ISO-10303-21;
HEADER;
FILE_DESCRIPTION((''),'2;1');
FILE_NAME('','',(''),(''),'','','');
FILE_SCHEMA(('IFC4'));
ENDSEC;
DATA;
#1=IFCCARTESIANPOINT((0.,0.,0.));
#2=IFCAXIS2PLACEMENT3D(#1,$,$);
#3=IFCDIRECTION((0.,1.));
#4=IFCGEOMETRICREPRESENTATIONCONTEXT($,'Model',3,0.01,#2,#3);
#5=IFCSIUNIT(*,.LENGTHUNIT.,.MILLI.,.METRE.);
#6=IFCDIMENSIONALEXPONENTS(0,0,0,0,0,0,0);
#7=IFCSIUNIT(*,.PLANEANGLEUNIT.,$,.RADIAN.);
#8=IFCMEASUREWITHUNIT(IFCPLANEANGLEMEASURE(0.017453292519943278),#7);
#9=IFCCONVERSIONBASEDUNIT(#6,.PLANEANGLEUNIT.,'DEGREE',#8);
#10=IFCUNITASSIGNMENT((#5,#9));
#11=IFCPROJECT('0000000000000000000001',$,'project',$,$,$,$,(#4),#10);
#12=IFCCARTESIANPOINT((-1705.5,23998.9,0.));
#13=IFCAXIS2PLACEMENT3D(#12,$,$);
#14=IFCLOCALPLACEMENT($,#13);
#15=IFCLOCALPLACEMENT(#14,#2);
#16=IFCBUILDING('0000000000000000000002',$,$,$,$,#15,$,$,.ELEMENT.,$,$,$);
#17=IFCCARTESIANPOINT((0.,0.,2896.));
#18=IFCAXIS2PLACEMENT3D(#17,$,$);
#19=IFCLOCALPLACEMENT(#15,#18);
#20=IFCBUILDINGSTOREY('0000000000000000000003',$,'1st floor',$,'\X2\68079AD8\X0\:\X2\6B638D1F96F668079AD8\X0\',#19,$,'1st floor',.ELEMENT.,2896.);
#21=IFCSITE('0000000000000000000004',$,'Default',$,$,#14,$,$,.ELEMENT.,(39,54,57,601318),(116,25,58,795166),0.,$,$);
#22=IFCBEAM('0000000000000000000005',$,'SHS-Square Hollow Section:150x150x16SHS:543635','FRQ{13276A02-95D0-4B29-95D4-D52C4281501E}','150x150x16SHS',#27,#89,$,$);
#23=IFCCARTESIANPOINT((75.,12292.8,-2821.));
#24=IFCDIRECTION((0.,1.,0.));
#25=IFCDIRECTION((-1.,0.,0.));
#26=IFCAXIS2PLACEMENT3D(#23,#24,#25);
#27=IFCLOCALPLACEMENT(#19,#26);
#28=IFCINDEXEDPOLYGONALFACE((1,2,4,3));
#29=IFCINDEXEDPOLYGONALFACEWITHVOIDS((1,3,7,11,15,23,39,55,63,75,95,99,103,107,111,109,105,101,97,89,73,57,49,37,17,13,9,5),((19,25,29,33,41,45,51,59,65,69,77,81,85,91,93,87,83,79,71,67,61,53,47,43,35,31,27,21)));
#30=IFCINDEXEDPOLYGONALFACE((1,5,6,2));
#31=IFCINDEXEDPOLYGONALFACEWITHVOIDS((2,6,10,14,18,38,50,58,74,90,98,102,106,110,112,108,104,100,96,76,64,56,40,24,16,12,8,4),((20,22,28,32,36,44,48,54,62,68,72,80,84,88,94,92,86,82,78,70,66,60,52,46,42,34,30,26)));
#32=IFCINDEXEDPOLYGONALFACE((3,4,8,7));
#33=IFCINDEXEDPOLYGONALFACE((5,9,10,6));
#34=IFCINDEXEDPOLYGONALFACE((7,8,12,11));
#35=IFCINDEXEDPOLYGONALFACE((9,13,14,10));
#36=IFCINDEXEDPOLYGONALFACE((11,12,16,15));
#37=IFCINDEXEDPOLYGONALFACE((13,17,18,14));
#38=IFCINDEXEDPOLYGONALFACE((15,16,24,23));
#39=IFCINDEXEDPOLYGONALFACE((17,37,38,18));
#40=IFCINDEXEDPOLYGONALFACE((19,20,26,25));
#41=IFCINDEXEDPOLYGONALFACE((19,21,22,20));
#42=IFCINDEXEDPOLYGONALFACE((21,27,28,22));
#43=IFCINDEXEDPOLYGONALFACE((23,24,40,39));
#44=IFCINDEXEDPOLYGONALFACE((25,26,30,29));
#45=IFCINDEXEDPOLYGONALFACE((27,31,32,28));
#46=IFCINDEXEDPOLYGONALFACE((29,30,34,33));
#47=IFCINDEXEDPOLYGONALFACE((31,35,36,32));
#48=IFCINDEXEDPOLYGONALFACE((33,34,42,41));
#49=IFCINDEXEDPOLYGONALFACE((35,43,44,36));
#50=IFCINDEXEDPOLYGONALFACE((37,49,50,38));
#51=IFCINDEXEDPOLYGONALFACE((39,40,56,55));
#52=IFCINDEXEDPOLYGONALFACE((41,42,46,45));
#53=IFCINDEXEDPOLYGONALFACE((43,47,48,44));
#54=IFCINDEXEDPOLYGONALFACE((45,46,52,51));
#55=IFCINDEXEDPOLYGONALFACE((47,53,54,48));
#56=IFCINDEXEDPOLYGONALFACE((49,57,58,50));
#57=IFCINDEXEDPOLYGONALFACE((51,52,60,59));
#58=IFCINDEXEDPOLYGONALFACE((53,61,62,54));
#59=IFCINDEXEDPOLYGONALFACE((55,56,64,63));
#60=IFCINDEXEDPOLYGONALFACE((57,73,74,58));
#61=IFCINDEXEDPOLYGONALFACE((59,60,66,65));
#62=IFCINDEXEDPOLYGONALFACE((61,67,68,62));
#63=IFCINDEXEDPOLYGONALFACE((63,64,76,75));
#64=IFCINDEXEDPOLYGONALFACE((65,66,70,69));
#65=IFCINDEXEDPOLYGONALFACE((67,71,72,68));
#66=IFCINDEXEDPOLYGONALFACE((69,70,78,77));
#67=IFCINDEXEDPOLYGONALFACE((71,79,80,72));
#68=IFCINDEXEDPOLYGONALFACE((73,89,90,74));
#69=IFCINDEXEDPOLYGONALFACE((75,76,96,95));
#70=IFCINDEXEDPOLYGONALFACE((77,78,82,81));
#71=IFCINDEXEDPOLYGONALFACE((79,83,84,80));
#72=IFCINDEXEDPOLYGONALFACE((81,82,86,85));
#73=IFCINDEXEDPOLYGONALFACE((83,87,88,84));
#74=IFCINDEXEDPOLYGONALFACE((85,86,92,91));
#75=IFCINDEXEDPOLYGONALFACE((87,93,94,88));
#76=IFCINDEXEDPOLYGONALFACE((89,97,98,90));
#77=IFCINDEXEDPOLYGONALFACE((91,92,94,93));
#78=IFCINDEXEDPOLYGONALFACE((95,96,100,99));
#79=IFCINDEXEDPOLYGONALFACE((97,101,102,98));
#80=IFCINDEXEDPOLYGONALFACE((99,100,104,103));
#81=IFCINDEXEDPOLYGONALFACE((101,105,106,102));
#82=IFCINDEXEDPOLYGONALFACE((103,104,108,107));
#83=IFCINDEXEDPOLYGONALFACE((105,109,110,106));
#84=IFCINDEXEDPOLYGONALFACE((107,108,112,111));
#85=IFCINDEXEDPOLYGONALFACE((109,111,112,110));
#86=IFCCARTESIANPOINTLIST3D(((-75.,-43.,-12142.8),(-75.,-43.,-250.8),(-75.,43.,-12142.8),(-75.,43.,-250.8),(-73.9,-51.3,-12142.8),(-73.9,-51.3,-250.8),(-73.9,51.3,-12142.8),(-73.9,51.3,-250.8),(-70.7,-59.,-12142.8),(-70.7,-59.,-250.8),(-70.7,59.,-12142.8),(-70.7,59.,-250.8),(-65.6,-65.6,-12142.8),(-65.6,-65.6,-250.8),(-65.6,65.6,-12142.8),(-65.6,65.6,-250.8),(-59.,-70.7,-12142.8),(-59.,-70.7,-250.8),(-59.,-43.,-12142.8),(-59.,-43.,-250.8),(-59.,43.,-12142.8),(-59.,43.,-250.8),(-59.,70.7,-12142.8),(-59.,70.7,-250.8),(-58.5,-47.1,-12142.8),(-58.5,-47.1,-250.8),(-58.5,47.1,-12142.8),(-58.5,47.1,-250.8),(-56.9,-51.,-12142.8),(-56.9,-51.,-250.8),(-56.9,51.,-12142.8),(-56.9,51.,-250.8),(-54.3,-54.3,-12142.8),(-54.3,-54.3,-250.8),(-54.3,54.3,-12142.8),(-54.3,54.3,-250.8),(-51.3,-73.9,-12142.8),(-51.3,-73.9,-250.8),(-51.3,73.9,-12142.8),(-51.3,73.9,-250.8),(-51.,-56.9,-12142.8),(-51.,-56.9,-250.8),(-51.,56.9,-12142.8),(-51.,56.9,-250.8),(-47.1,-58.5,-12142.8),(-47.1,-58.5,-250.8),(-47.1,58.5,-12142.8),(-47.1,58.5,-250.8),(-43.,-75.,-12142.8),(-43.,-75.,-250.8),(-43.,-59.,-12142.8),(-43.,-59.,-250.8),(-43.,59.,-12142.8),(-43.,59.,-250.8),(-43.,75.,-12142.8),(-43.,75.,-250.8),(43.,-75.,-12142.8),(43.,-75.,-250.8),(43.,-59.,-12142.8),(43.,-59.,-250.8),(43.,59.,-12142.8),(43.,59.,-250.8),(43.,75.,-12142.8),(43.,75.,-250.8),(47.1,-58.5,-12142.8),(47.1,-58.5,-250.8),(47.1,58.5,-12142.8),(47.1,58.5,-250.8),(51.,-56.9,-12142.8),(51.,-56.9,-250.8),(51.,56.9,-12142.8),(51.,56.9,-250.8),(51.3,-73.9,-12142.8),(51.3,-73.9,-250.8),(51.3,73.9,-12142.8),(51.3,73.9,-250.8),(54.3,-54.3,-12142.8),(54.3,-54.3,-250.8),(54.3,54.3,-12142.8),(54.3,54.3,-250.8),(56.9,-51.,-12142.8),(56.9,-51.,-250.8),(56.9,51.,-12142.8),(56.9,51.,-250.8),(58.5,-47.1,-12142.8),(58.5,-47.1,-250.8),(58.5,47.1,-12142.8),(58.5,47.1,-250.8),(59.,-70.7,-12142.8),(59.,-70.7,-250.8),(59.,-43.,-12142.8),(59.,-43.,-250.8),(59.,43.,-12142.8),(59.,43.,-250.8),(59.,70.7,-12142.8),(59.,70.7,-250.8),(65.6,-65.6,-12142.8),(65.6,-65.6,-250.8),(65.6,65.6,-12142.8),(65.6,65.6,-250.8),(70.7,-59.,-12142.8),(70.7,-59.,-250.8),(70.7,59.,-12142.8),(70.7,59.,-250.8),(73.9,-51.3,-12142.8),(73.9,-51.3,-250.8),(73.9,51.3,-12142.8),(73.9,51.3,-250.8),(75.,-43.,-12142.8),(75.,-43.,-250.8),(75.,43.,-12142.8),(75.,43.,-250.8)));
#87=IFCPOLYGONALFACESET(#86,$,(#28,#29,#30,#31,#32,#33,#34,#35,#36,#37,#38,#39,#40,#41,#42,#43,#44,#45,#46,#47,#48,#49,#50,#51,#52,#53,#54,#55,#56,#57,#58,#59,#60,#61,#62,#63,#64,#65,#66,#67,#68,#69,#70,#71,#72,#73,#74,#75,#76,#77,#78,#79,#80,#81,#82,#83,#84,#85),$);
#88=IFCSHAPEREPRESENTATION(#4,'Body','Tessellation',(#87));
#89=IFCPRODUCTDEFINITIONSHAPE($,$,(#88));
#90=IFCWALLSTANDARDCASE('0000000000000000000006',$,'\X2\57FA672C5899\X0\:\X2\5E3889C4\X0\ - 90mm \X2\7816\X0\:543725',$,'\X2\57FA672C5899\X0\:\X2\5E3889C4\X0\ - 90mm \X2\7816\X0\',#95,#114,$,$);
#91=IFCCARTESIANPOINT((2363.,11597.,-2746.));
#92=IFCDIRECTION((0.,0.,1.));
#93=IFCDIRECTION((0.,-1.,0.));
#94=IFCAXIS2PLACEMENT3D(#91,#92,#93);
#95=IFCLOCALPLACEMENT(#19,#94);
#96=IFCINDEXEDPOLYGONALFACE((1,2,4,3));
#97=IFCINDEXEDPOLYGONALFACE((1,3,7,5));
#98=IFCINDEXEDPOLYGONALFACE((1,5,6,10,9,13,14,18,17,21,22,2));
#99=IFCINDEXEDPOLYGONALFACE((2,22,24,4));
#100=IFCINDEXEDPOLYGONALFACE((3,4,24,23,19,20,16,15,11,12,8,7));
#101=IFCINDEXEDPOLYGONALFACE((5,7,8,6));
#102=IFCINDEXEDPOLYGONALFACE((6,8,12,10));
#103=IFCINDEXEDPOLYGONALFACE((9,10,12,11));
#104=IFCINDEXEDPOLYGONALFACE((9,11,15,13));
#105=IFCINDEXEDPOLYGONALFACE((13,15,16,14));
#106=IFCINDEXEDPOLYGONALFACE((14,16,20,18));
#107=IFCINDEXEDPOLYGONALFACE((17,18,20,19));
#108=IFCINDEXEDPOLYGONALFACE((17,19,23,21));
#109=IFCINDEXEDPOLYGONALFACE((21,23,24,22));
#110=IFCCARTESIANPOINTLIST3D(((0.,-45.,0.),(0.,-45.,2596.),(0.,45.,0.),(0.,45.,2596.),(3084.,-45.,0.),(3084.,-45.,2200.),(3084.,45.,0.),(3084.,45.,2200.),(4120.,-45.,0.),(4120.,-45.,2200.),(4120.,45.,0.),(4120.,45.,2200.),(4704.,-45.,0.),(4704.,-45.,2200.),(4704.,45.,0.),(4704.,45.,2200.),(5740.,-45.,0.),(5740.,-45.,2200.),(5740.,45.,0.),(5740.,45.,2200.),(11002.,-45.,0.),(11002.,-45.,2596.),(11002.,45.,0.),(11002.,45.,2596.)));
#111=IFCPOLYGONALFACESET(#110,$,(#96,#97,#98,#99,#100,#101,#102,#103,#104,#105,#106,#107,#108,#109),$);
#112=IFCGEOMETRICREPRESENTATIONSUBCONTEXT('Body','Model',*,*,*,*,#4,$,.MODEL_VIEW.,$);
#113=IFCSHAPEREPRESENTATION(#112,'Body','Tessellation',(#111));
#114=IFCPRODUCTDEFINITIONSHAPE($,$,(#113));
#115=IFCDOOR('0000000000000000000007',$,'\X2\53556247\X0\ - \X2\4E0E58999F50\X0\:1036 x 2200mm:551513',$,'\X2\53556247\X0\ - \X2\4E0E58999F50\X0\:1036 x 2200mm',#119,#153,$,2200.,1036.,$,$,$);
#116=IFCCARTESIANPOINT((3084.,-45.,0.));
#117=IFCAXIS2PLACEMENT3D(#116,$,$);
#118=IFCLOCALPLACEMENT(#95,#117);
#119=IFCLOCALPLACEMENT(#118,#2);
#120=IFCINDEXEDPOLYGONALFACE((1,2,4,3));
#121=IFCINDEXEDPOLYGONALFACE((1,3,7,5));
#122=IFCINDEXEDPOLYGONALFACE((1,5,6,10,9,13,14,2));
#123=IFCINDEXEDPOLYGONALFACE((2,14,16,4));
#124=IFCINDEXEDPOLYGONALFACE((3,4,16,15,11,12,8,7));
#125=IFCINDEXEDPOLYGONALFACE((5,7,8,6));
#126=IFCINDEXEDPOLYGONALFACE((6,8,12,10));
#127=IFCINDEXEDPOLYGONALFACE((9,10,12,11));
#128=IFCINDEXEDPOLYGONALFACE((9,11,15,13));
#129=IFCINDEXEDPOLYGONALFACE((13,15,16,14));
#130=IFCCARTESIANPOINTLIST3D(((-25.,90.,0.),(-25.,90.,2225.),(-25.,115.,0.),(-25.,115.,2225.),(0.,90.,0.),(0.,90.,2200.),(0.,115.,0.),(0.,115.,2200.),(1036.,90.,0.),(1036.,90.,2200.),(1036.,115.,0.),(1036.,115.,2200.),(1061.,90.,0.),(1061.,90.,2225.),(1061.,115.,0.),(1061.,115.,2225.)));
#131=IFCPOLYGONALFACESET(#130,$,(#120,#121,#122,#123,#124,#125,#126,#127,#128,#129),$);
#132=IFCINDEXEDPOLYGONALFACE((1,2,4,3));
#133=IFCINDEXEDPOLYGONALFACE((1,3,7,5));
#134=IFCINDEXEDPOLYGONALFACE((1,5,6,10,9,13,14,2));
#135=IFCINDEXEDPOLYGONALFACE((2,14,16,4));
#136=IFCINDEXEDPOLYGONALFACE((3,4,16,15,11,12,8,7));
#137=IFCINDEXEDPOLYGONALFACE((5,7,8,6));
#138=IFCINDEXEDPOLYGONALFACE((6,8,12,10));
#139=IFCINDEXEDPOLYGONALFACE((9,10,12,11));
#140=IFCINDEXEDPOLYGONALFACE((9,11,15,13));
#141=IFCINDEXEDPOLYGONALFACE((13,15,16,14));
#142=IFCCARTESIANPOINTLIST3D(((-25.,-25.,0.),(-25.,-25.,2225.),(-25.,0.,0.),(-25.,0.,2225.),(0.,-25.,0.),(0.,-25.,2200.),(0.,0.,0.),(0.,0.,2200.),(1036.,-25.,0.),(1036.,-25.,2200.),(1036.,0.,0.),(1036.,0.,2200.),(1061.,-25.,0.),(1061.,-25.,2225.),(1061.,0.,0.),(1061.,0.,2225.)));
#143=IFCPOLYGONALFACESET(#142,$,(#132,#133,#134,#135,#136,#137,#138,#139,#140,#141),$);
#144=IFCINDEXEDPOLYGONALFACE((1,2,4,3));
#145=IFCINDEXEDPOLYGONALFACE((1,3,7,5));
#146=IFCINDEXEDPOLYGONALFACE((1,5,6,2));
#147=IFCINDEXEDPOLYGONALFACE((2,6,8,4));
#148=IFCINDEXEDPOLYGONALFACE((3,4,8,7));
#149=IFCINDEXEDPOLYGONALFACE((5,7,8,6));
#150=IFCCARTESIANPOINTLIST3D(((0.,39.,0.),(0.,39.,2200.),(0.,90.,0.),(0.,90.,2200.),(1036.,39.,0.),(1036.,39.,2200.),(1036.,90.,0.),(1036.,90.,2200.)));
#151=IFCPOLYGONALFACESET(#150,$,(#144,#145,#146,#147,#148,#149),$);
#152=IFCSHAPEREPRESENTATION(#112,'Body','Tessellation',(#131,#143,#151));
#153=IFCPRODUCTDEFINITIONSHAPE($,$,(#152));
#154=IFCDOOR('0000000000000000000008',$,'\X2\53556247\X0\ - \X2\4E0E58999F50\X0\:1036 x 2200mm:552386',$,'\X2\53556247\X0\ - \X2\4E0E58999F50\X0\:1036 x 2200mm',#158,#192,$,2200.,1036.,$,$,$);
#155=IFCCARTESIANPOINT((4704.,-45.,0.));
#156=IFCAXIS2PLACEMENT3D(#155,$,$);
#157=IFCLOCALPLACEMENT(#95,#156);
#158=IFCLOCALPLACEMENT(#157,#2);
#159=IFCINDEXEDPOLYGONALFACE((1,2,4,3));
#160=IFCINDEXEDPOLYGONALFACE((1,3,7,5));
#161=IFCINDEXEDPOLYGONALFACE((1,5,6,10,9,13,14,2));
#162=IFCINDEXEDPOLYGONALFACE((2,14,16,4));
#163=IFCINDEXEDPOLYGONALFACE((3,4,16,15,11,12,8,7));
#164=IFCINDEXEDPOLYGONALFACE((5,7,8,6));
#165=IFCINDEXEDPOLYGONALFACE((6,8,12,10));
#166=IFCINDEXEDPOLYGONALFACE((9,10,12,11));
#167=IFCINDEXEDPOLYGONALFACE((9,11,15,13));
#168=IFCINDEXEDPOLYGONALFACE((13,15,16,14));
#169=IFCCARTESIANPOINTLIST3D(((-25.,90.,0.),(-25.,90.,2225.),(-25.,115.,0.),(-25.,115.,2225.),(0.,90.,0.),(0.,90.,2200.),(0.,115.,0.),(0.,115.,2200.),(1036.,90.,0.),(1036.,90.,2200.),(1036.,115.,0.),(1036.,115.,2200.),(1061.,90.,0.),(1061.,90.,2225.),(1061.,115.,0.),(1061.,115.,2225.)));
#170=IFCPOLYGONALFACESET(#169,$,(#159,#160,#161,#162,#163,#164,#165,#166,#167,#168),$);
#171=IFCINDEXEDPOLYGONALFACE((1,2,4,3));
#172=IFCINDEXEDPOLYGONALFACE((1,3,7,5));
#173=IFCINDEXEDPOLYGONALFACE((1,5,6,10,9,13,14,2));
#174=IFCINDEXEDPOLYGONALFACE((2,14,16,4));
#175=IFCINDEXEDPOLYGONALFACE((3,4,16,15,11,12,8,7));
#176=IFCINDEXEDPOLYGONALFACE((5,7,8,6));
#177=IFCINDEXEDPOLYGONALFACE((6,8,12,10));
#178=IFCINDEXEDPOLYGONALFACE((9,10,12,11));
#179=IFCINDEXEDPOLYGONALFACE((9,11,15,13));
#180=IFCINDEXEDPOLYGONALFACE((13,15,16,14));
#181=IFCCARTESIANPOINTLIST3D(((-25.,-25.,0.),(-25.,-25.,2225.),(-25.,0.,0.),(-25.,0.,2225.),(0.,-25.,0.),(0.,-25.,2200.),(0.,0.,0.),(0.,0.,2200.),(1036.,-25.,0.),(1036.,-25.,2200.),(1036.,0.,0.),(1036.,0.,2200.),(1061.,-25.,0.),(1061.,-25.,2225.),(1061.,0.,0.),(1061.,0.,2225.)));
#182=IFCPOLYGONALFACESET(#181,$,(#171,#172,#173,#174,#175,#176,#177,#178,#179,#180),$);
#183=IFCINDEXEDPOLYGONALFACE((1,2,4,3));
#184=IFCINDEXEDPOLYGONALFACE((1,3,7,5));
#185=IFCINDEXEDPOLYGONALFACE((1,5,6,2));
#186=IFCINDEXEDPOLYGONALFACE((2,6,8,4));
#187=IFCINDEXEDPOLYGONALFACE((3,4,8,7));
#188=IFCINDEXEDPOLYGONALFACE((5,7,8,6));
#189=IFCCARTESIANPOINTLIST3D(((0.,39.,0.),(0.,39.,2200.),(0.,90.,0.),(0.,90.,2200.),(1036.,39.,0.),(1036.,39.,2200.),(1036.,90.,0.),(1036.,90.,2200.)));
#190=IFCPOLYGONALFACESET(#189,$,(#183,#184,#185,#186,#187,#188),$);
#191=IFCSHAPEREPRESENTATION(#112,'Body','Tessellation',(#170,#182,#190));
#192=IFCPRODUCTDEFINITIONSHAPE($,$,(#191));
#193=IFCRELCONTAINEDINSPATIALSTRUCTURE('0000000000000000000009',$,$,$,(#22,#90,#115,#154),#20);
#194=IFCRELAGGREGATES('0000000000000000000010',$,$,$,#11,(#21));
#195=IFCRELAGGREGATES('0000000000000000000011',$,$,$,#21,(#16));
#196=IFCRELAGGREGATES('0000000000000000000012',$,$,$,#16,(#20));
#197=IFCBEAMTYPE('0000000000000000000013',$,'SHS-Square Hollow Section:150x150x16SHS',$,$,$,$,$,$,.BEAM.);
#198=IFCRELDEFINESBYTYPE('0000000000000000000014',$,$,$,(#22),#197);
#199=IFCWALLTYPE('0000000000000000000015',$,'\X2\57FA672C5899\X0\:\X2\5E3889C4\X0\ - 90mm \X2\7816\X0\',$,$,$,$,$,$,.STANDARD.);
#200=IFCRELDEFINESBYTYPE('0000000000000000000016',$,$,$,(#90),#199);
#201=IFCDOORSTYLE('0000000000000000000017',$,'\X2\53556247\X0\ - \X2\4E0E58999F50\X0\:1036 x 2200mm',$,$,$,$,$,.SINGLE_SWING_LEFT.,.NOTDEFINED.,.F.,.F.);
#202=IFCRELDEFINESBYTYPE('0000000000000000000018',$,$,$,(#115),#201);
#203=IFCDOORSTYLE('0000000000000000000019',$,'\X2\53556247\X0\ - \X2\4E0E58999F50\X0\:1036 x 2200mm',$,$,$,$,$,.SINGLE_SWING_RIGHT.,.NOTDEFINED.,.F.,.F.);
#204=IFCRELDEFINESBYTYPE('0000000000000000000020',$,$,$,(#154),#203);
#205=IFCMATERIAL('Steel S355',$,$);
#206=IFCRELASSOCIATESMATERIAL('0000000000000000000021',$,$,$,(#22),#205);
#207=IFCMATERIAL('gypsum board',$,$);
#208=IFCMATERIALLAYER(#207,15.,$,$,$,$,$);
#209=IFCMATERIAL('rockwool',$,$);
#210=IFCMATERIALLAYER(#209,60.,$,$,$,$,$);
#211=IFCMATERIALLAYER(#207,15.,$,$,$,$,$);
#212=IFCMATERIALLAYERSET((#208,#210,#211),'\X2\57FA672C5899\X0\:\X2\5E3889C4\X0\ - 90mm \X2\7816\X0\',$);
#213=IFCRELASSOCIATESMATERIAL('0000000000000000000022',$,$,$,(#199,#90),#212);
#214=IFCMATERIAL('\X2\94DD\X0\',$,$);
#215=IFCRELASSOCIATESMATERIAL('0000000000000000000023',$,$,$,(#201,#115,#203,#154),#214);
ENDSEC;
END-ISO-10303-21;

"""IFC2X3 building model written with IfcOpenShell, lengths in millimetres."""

from ifc_helpers import new_model, entity, si_unit, converted_unit, direction, frame, frame_2d, origin, origin_2d, origin_2d_with_axis, place, context, subcontext, project, spatial, polyline, rectangle, hollow_rectangle, outline, extrude, clip, halfspace, source, transform, mapped, material, layer, layer_set, layer_usage, type_object, type_shapes, element, fill, save


model = new_model("IFC2X3")

# Units and contexts
model_context = context("Model", 3, precision=0.01, world=origin(), true_north=direction((0.0, 1.0)))
body_context = subcontext(model_context, "Body", "Model", "MODEL_VIEW")
ifc_project = project(units=[si_unit("LENGTHUNIT", "METRE", prefix="MILLI"), converted_unit("PLANEANGLEUNIT", "DEGREE", entity("IfcPlaneAngleMeasure", 0.017453292519943278), si_unit("PLANEANGLEUNIT", "RADIAN"), dimensions=[0, 0, 0, 0, 0, 0, 0])], contexts=[model_context])

# Site, building, storey
site_placement = place(None, frame((-1705.5, 23998.9, 0.0)))
site = spatial("IfcSite", under=ifc_project, at=site_placement, Name="Default", CompositionType="ELEMENT", RefLatitude=(39, 54, 57, 601318), RefLongitude=(116, 25, 58, 795166), RefElevation=0.0)
building_placement = place(site_placement, origin())
building = spatial("IfcBuilding", under=site, at=building_placement, CompositionType="ELEMENT")
storey_placement = place(building_placement, frame((0.0, 0.0, 2896.0)))
storey = spatial("IfcBuildingStorey", under=building, at=storey_placement, Name="1st floor", ObjectType="标高:正负零标高", LongName="1st floor", CompositionType="ELEMENT", Elevation=2896.0)

# Shared definitions
ifc_material_1 = material(Name="Steel S355")

# Beam
beam_type_1 = type_object("IfcBeamType", Name="SHS-Square Hollow Section:150x150x16SHS", PredefinedType="BEAM")
beam_1_placement = place(storey_placement, frame((75.0, 12292.8, -2821.0), z_axis=(0.0, 1.0, 0.0), x_axis=(-1.0, 0.0, 0.0)))
element("IfcBeam", 1, at=beam_1_placement, inside=storey, type_object=beam_type_1, material=ifc_material_1, Name="SHS-Square Hollow Section:150x150x16SHS:543635", Description="FRQ{13276A02-95D0-4B29-95D4-D52C4281501E}", ObjectType="150x150x16SHS", context=model_context, shape_type="Clipping", body=[
    clip(clip(extrude(hollow_rectangle(XDim=150.0, YDim=150.0, WallThickness=16.0, InnerFilletRadius=16.0, OuterFilletRadius=32.0, at=origin_2d()), origin(), (0.0, 0.0, -1.0), 12398.9), halfspace(frame((75.0, -75.0, -12142.8), z_axis=(0.0, 0.0, 1.0), x_axis=(1.0, 0.0, 0.0)), True)), halfspace(frame((75.0, -75.0, -250.8), z_axis=(0.0, 0.0, -1.0), x_axis=(-1.0, 0.0, 0.0)), True)),
])

# Shared definitions
ifc_material_2 = material(Name="gypsum board")
ifc_layer_1 = layer(ifc_material_2, 15.0)
ifc_material_3 = material(Name="rockwool")
ifc_layer_2 = layer(ifc_material_3, 60.0)
ifc_layer_3 = layer(ifc_material_2, 15.0)
ifc_layer_set = layer_set([ifc_layer_1, ifc_layer_2, ifc_layer_3], Name="基本墙:常规 - 90mm 砖")
wall_type = type_object("IfcWallType", Name="基本墙:常规 - 90mm 砖", PredefinedType="STANDARD", material=ifc_layer_set)

# Wall, openings, doors
ifc_layer_usage_1 = layer_usage(ifc_layer_set, "AXIS2", "NEGATIVE", 45.0)
wall_1_placement = place(storey_placement, frame((2363.0, 11597.0, -2746.0), z_axis=(0.0, 0.0, 1.0), x_axis=(0.0, -1.0, 0.0)))
wall_1 = element("IfcWallStandardCase", 2, at=wall_1_placement, inside=storey, type_object=wall_type, material=ifc_layer_usage_1, Name="基本墙:常规 - 90mm 砖:543725", ObjectType="基本墙:常规 - 90mm 砖", context=body_context, shape_type="SweptSolid", body=[
    extrude(rectangle(XDim=11002.0, YDim=90.0, at=frame_2d((5501.0, 0.0), x_axis=(1.0, 0.0))), origin(), (0.0, 0.0, 1.0), 2596.0),
])
opening_1_placement = place(wall_1_placement, frame((3084.0, -45.0, 0.0)))
opening_1 = element("IfcOpeningElement", 3, at=opening_1_placement, cuts=wall_1, ObjectType="Opening", context=body_context, shape_type="SweptSolid", body=[
    extrude(rectangle(XDim=1036.0, YDim=2200.0, at=frame_2d((1100.0, 518.0), x_axis=(0.0, -1.0))), frame((0.0, 0.0, 0.0), z_axis=(0.0, 1.0, 0.0), x_axis=(0.0, 0.0, 1.0)), (0.0, 0.0, 1.0), 90.0),
])
opening_2_placement = place(wall_1_placement, frame((4704.0, -45.0, 0.0)))
opening_2 = element("IfcOpeningElement", 4, at=opening_2_placement, cuts=wall_1, ObjectType="Opening", context=body_context, shape_type="SweptSolid", body=[
    extrude(rectangle(XDim=1036.0, YDim=2200.0, at=frame_2d((1100.0, 518.0), x_axis=(0.0, 1.0))), frame((0.0, 0.0, 0.0), z_axis=(0.0, 1.0, 0.0), x_axis=(0.0, 0.0, 1.0)), (0.0, 0.0, 1.0), 90.0),
])
ifc_material_4 = material(Name="铝")
door_style_1 = type_object("IfcDoorStyle", Name="单扇 - 与墙齐:1036 x 2200mm", ConstructionType="NOTDEFINED", OperationType="SINGLE_SWING_LEFT", ParameterTakesPrecedence=False, Sizeable=False, material=ifc_material_4)
shared_shape_1 = source(origin(), body_context, "Body", "SweptSolid", [
    extrude(outline(polyline([(-543.0, -1118.7), (543.0, -1118.7), (543.0, 1106.3), (518.0, 1106.3), (518.0, -1093.8), (-518.0, -1093.8), (-518.0, 1106.3), (-543.0, 1106.3), (-543.0, -1118.7)])), frame((518.0, 115.0, 1106.3), z_axis=(0.0, -1.0, 0.0), x_axis=(-1.0, 0.0, 0.0)), (0.0, 0.0, 1.0), 25.0),
    extrude(outline(polyline([(-1118.7, -543.0), (1106.2, -543.0), (1106.2, -518.0), (-1093.7, -518.0), (-1093.7, 518.0), (1106.2, 518.0), (1106.2, 543.0), (-1118.7, 543.0), (-1118.7, -543.0)])), frame((518.0, 0.0, 1106.2), z_axis=(0.0, -1.0, 0.0), x_axis=(0.0, 0.0, -1.0)), (0.0, 0.0, 1.0), 25.0),
    extrude(rectangle(XDim=1036.0, YDim=51.0, at=origin_2d_with_axis()), frame((518.0, 64.5, 0.0)), (0.0, 0.0, 1.0), 2200.0),
])
type_shapes(door_style_1, [shared_shape_1])
door_1_placement = place(opening_1_placement, origin())
door_1 = element("IfcDoor", 5, at=door_1_placement, inside=storey, type_object=door_style_1, material=ifc_material_4, Name="单扇 - 与墙齐:1036 x 2200mm:551513", ObjectType="单扇 - 与墙齐:1036 x 2200mm", OverallHeight=2200.0, OverallWidth=1036.0, context=body_context, shape_type="MappedRepresentation", body=[
    mapped(shared_shape_1, transform((0.0, 0.0, 0.0), scale=1.0)),
])
fill(opening_1, door_1)
door_style_2 = type_object("IfcDoorStyle", Name="单扇 - 与墙齐:1036 x 2200mm", ConstructionType="NOTDEFINED", OperationType="SINGLE_SWING_RIGHT", ParameterTakesPrecedence=False, Sizeable=False, material=ifc_material_4)
shared_shape_2 = source(origin(), body_context, "Body", "SweptSolid", [
    extrude(outline(polyline([(-543.0, -1118.7), (543.0, -1118.7), (543.0, 1106.3), (518.0, 1106.3), (518.0, -1093.8), (-518.0, -1093.8), (-518.0, 1106.3), (-543.0, 1106.3), (-543.0, -1118.7)])), frame((518.0, 90.0, 1106.3), z_axis=(0.0, 1.0, 0.0), x_axis=(1.0, 0.0, 0.0)), (0.0, 0.0, 1.0), 25.0),
    extrude(outline(polyline([(-1118.7, -543.0), (1106.2, -543.0), (1106.2, -518.0), (-1093.7, -518.0), (-1093.7, 518.0), (1106.2, 518.0), (1106.2, 543.0), (-1118.7, 543.0), (-1118.7, -543.0)])), frame((518.0, -25.0, 1106.2), z_axis=(0.0, 1.0, 0.0), x_axis=(0.0, 0.0, -1.0)), (0.0, 0.0, 1.0), 25.0),
    extrude(rectangle(XDim=51.0, YDim=1036.0, at=origin_2d_with_axis()), frame((518.0, 64.5, 0.0), z_axis=(0.0, 0.0, 1.0), x_axis=(0.0, 1.0, 0.0)), (0.0, 0.0, 1.0), 2200.0),
])
type_shapes(door_style_2, [shared_shape_2])
door_2_placement = place(opening_2_placement, origin())
door_2 = element("IfcDoor", 6, at=door_2_placement, inside=storey, type_object=door_style_2, material=ifc_material_4, Name="单扇 - 与墙齐:1036 x 2200mm:552386", ObjectType="单扇 - 与墙齐:1036 x 2200mm", OverallHeight=2200.0, OverallWidth=1036.0, context=body_context, shape_type="MappedRepresentation", body=[
    mapped(shared_shape_2, transform((0.0, 0.0, 0.0), scale=1.0)),
])
fill(opening_2, door_2)

save(model, "model.ifc")
